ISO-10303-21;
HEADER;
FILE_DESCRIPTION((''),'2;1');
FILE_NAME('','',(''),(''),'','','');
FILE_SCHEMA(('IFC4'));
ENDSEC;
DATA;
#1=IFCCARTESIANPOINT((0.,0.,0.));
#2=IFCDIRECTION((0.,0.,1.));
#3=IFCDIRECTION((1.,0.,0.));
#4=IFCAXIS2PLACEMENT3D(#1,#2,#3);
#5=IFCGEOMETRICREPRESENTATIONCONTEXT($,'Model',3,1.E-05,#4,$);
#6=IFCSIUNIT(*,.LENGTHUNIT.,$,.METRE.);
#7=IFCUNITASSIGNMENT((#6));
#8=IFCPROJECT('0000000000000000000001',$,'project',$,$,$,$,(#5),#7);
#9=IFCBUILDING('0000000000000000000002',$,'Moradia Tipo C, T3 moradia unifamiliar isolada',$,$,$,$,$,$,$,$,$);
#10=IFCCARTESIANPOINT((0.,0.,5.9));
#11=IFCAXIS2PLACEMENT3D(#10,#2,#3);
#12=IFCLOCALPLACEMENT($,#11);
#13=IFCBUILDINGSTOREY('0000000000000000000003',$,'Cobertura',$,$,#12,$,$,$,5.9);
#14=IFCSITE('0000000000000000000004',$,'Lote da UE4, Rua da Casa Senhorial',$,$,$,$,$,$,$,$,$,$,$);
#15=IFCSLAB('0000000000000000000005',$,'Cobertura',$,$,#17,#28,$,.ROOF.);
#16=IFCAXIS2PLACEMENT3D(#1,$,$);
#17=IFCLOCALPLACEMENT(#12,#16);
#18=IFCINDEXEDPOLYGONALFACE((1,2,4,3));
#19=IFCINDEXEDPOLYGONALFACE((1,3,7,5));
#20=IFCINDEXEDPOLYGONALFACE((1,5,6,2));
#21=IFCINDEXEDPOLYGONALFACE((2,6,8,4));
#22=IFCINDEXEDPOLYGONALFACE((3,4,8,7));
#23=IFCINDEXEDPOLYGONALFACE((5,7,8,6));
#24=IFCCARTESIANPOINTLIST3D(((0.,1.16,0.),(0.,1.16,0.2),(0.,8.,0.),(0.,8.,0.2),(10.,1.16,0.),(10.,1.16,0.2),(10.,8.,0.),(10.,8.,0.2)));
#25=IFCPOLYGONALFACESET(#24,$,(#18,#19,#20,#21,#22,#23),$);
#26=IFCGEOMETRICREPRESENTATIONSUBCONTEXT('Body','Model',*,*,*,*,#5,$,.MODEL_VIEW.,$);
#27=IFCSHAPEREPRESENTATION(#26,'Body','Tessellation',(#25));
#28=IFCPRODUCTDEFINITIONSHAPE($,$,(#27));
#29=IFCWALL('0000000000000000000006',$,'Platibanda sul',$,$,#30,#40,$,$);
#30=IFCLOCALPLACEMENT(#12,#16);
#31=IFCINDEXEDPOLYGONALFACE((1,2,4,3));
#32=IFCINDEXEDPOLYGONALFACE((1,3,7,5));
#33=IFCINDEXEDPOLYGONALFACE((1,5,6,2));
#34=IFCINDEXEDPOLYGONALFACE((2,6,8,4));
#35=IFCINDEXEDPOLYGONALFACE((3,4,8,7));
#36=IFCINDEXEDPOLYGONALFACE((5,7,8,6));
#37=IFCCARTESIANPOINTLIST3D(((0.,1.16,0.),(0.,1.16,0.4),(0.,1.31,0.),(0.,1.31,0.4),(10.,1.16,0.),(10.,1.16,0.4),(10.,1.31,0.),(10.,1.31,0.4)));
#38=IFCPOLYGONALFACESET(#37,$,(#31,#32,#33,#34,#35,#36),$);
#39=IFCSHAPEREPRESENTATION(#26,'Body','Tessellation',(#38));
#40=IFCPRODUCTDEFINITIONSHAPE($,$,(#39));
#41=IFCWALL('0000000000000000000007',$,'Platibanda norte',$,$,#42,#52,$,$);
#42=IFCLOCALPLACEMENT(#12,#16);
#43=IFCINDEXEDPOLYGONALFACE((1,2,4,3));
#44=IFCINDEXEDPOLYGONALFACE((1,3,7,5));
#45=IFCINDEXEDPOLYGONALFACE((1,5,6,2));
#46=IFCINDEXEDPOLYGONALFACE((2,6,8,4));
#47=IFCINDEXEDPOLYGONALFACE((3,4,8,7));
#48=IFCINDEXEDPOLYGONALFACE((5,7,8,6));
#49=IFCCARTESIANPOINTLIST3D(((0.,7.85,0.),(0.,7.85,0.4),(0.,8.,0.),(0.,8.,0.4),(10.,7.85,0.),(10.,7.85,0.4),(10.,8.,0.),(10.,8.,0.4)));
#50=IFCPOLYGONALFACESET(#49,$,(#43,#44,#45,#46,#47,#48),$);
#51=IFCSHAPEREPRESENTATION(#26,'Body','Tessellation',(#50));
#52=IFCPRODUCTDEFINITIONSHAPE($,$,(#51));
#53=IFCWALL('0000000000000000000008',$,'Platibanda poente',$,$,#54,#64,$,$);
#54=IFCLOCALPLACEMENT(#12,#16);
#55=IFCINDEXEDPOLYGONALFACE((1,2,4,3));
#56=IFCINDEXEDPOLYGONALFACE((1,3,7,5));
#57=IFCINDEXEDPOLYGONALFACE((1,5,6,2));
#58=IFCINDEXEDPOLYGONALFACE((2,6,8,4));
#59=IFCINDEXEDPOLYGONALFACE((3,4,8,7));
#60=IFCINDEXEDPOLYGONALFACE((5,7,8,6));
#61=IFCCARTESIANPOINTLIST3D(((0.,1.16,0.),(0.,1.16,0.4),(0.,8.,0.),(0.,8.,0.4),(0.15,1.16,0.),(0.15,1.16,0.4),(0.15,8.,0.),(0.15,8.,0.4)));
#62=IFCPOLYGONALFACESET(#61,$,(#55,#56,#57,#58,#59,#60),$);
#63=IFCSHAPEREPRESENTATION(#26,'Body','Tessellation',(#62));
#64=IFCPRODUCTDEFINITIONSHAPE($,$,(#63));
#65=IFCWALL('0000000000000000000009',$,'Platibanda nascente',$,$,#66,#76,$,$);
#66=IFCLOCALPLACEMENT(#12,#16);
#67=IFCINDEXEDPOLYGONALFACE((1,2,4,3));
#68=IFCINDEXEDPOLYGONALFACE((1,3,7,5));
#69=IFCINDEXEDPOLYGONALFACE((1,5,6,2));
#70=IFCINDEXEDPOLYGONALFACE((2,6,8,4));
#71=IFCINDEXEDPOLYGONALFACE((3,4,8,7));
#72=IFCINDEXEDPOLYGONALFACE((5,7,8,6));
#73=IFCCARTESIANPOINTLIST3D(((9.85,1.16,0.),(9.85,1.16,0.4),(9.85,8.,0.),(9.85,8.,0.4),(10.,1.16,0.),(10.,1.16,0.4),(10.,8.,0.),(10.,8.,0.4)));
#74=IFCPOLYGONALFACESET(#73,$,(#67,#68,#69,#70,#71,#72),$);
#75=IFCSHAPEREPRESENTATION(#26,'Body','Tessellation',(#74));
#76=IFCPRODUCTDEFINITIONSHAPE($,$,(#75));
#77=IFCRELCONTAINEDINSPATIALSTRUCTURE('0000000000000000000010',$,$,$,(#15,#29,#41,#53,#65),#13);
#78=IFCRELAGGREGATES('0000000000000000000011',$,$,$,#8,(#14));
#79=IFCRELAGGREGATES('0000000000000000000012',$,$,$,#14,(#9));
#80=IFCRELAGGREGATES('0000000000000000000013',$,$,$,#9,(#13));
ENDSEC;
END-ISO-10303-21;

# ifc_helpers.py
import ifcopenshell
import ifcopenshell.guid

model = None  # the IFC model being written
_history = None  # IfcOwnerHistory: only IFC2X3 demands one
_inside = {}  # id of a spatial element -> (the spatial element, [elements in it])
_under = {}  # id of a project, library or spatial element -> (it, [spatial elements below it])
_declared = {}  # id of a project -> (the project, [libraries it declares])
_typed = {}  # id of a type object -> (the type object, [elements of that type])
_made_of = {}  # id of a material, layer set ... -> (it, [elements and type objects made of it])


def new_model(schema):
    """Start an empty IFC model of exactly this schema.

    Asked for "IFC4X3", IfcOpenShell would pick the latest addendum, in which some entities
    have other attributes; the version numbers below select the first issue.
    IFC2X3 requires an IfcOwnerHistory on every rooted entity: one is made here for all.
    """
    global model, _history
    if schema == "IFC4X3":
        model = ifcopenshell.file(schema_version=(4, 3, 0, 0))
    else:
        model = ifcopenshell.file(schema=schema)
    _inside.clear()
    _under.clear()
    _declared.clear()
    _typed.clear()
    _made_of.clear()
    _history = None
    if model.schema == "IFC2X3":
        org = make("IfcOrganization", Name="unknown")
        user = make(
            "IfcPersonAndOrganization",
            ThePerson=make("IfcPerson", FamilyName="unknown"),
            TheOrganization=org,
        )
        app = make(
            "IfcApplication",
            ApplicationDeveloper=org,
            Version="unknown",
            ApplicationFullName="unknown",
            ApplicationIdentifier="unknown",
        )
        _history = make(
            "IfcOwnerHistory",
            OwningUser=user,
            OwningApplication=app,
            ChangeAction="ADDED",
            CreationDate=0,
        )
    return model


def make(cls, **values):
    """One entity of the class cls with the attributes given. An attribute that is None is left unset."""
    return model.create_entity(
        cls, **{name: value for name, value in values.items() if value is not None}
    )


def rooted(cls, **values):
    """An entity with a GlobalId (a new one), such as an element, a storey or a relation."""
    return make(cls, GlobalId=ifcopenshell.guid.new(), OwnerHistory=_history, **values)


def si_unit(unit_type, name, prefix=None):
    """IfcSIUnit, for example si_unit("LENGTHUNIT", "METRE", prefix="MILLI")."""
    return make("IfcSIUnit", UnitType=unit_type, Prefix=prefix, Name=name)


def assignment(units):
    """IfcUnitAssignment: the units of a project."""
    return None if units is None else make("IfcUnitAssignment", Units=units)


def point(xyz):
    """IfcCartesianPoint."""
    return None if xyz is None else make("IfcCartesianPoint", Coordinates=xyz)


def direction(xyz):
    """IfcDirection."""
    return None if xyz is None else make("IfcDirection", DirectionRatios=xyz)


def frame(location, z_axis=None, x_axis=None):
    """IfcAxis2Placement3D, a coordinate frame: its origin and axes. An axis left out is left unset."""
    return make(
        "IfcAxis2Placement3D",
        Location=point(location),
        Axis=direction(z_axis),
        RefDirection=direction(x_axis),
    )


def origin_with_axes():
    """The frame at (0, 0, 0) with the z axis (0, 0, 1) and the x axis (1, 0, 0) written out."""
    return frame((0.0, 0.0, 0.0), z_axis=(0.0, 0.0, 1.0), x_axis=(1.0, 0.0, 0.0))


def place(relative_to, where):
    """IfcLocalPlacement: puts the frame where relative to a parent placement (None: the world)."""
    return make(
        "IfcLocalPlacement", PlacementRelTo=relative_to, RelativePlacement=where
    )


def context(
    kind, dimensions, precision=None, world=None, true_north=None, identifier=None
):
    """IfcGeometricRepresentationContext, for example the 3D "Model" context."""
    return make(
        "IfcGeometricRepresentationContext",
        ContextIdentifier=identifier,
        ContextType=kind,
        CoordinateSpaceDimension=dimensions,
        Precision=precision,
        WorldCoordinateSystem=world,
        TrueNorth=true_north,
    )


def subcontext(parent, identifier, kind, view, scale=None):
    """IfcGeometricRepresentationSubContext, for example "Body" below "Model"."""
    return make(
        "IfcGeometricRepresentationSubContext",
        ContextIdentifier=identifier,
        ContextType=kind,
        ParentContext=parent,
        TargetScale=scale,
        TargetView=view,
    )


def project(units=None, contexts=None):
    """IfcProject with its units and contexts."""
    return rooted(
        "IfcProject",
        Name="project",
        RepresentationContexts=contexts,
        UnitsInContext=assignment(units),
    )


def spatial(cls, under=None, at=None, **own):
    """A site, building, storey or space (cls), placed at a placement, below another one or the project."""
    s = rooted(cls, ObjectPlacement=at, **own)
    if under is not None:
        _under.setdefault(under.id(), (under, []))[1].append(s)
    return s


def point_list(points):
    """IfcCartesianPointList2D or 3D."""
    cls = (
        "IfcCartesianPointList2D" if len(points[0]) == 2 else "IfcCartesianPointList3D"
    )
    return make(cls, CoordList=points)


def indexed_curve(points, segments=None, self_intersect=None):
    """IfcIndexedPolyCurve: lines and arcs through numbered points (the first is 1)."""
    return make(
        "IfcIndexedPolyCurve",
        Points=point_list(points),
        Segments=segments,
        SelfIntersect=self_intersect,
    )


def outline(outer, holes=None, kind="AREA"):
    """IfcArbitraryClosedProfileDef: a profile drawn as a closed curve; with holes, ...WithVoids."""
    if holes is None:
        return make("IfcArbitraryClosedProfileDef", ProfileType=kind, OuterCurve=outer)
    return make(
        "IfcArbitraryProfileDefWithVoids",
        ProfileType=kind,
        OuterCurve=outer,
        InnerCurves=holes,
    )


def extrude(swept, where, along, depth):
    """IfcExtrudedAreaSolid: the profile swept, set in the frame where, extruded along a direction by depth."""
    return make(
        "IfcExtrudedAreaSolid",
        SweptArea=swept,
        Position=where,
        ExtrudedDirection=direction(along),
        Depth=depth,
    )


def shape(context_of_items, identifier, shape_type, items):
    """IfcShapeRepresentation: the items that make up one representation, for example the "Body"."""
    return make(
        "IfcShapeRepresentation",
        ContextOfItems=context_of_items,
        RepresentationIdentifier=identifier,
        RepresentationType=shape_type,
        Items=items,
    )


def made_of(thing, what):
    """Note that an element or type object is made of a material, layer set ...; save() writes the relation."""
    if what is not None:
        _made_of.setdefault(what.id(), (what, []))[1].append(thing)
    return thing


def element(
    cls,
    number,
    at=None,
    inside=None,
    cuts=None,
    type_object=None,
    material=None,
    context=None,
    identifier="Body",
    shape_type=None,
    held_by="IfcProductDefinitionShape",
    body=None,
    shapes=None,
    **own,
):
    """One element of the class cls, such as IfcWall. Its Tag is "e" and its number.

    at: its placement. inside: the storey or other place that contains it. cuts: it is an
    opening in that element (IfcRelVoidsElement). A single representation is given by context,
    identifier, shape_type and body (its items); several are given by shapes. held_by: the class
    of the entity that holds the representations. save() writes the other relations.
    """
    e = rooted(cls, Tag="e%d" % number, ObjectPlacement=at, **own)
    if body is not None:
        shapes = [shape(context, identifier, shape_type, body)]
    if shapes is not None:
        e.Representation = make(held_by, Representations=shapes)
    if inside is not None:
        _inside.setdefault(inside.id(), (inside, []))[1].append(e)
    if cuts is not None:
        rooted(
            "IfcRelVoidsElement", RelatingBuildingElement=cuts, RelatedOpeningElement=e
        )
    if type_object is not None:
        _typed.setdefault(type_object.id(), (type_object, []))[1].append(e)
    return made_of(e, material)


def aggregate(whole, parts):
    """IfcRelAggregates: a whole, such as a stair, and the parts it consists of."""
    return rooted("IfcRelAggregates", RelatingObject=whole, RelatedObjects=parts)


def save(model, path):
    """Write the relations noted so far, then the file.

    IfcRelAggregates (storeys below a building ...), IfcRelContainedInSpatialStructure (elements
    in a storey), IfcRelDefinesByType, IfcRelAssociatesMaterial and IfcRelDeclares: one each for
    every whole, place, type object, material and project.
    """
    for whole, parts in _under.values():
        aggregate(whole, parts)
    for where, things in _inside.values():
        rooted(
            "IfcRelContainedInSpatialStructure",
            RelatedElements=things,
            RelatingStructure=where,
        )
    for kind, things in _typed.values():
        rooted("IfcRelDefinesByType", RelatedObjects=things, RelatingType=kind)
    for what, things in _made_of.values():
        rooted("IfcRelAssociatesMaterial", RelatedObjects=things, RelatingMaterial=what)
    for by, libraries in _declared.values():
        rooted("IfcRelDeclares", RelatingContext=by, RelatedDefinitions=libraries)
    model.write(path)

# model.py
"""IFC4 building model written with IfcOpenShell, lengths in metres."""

from ifc_helpers import new_model, si_unit, frame, origin_with_axes, place, context, subcontext, project, spatial, indexed_curve, outline, extrude, element, save


model = new_model("IFC4")

# Units and contexts
model_context = context("Model", 3, precision=1e-05, world=origin_with_axes())
body_context = subcontext(model_context, "Body", "Model", "MODEL_VIEW")
ifc_project = project(units=[si_unit("LENGTHUNIT", "METRE")], contexts=[model_context])

# Site, building, storey
site = spatial("IfcSite", under=ifc_project, Name="Lote da UE4, Rua da Casa Senhorial")
building = spatial("IfcBuilding", under=site, Name="Moradia Tipo C, T3 moradia unifamiliar isolada")
storey_placement = place(None, frame((0.0, 0.0, 5.9), z_axis=(0.0, 0.0, 1.0), x_axis=(1.0, 0.0, 0.0)))
storey = spatial("IfcBuildingStorey", under=building, at=storey_placement, Name="Cobertura", Elevation=5.9)

# Slab
slab_placement = place(storey_placement, frame((0.0, 1.16, 0.0), z_axis=(0.0, 0.0, 1.0), x_axis=(1.0, 0.0, 0.0)))
element("IfcSlab", 1, at=slab_placement, inside=storey, Name="Cobertura", PredefinedType="ROOF", context=body_context, shape_type="SweptSolid", body=[
    extrude(outline(indexed_curve([(0.0, 0.0), (10.0, 0.0), (10.0, 6.84), (0.0, 6.84), (0.0, 0.0)])), None, (0.0, 0.0, 1.0), 0.2),
])

# Walls
for number, where, z_axis, x_axis, name in (
    (2, (0.0, 1.16, 0.0), (0.0, 0.0, 1.0), (1.0, 0.0, 0.0), "Platibanda sul"),
    (3, (0.0, 7.85, 0.0), (0.0, 0.0, 1.0), (1.0, 0.0, 0.0), "Platibanda norte"),
):
    element("IfcWall", number, at=place(storey_placement, frame(where, z_axis=z_axis, x_axis=x_axis)), inside=storey, Name=name, context=body_context, shape_type="SweptSolid", body=[
        extrude(outline(indexed_curve([(0.0, 0.0), (0.0, 0.15), (10.0, 0.15), (10.0, 0.0), (0.0, 0.0)], self_intersect=False)), origin_with_axes(), (0.0, 0.0, 1.0), 0.4),
    ])
for number, where, z_axis, x_axis, name in (
    (4, (0.15, 1.16, 0.0), (0.0, 0.0, 1.0), (0.0, 1.0, 0.0), "Platibanda poente"),
    (5, (10.0, 1.16, 0.0), (0.0, 0.0, 1.0), (0.0, 1.0, 0.0), "Platibanda nascente"),
):
    element("IfcWall", number, at=place(storey_placement, frame(where, z_axis=z_axis, x_axis=x_axis)), inside=storey, Name=name, context=body_context, shape_type="SweptSolid", body=[
        extrude(outline(indexed_curve([(0.0, 0.0), (0.0, 0.15), (6.84, 0.15), (6.84, 0.0), (0.0, 0.0)], self_intersect=False)), origin_with_axes(), (0.0, 0.0, 1.0), 0.4),
    ])

save(model, "model.ifc")
